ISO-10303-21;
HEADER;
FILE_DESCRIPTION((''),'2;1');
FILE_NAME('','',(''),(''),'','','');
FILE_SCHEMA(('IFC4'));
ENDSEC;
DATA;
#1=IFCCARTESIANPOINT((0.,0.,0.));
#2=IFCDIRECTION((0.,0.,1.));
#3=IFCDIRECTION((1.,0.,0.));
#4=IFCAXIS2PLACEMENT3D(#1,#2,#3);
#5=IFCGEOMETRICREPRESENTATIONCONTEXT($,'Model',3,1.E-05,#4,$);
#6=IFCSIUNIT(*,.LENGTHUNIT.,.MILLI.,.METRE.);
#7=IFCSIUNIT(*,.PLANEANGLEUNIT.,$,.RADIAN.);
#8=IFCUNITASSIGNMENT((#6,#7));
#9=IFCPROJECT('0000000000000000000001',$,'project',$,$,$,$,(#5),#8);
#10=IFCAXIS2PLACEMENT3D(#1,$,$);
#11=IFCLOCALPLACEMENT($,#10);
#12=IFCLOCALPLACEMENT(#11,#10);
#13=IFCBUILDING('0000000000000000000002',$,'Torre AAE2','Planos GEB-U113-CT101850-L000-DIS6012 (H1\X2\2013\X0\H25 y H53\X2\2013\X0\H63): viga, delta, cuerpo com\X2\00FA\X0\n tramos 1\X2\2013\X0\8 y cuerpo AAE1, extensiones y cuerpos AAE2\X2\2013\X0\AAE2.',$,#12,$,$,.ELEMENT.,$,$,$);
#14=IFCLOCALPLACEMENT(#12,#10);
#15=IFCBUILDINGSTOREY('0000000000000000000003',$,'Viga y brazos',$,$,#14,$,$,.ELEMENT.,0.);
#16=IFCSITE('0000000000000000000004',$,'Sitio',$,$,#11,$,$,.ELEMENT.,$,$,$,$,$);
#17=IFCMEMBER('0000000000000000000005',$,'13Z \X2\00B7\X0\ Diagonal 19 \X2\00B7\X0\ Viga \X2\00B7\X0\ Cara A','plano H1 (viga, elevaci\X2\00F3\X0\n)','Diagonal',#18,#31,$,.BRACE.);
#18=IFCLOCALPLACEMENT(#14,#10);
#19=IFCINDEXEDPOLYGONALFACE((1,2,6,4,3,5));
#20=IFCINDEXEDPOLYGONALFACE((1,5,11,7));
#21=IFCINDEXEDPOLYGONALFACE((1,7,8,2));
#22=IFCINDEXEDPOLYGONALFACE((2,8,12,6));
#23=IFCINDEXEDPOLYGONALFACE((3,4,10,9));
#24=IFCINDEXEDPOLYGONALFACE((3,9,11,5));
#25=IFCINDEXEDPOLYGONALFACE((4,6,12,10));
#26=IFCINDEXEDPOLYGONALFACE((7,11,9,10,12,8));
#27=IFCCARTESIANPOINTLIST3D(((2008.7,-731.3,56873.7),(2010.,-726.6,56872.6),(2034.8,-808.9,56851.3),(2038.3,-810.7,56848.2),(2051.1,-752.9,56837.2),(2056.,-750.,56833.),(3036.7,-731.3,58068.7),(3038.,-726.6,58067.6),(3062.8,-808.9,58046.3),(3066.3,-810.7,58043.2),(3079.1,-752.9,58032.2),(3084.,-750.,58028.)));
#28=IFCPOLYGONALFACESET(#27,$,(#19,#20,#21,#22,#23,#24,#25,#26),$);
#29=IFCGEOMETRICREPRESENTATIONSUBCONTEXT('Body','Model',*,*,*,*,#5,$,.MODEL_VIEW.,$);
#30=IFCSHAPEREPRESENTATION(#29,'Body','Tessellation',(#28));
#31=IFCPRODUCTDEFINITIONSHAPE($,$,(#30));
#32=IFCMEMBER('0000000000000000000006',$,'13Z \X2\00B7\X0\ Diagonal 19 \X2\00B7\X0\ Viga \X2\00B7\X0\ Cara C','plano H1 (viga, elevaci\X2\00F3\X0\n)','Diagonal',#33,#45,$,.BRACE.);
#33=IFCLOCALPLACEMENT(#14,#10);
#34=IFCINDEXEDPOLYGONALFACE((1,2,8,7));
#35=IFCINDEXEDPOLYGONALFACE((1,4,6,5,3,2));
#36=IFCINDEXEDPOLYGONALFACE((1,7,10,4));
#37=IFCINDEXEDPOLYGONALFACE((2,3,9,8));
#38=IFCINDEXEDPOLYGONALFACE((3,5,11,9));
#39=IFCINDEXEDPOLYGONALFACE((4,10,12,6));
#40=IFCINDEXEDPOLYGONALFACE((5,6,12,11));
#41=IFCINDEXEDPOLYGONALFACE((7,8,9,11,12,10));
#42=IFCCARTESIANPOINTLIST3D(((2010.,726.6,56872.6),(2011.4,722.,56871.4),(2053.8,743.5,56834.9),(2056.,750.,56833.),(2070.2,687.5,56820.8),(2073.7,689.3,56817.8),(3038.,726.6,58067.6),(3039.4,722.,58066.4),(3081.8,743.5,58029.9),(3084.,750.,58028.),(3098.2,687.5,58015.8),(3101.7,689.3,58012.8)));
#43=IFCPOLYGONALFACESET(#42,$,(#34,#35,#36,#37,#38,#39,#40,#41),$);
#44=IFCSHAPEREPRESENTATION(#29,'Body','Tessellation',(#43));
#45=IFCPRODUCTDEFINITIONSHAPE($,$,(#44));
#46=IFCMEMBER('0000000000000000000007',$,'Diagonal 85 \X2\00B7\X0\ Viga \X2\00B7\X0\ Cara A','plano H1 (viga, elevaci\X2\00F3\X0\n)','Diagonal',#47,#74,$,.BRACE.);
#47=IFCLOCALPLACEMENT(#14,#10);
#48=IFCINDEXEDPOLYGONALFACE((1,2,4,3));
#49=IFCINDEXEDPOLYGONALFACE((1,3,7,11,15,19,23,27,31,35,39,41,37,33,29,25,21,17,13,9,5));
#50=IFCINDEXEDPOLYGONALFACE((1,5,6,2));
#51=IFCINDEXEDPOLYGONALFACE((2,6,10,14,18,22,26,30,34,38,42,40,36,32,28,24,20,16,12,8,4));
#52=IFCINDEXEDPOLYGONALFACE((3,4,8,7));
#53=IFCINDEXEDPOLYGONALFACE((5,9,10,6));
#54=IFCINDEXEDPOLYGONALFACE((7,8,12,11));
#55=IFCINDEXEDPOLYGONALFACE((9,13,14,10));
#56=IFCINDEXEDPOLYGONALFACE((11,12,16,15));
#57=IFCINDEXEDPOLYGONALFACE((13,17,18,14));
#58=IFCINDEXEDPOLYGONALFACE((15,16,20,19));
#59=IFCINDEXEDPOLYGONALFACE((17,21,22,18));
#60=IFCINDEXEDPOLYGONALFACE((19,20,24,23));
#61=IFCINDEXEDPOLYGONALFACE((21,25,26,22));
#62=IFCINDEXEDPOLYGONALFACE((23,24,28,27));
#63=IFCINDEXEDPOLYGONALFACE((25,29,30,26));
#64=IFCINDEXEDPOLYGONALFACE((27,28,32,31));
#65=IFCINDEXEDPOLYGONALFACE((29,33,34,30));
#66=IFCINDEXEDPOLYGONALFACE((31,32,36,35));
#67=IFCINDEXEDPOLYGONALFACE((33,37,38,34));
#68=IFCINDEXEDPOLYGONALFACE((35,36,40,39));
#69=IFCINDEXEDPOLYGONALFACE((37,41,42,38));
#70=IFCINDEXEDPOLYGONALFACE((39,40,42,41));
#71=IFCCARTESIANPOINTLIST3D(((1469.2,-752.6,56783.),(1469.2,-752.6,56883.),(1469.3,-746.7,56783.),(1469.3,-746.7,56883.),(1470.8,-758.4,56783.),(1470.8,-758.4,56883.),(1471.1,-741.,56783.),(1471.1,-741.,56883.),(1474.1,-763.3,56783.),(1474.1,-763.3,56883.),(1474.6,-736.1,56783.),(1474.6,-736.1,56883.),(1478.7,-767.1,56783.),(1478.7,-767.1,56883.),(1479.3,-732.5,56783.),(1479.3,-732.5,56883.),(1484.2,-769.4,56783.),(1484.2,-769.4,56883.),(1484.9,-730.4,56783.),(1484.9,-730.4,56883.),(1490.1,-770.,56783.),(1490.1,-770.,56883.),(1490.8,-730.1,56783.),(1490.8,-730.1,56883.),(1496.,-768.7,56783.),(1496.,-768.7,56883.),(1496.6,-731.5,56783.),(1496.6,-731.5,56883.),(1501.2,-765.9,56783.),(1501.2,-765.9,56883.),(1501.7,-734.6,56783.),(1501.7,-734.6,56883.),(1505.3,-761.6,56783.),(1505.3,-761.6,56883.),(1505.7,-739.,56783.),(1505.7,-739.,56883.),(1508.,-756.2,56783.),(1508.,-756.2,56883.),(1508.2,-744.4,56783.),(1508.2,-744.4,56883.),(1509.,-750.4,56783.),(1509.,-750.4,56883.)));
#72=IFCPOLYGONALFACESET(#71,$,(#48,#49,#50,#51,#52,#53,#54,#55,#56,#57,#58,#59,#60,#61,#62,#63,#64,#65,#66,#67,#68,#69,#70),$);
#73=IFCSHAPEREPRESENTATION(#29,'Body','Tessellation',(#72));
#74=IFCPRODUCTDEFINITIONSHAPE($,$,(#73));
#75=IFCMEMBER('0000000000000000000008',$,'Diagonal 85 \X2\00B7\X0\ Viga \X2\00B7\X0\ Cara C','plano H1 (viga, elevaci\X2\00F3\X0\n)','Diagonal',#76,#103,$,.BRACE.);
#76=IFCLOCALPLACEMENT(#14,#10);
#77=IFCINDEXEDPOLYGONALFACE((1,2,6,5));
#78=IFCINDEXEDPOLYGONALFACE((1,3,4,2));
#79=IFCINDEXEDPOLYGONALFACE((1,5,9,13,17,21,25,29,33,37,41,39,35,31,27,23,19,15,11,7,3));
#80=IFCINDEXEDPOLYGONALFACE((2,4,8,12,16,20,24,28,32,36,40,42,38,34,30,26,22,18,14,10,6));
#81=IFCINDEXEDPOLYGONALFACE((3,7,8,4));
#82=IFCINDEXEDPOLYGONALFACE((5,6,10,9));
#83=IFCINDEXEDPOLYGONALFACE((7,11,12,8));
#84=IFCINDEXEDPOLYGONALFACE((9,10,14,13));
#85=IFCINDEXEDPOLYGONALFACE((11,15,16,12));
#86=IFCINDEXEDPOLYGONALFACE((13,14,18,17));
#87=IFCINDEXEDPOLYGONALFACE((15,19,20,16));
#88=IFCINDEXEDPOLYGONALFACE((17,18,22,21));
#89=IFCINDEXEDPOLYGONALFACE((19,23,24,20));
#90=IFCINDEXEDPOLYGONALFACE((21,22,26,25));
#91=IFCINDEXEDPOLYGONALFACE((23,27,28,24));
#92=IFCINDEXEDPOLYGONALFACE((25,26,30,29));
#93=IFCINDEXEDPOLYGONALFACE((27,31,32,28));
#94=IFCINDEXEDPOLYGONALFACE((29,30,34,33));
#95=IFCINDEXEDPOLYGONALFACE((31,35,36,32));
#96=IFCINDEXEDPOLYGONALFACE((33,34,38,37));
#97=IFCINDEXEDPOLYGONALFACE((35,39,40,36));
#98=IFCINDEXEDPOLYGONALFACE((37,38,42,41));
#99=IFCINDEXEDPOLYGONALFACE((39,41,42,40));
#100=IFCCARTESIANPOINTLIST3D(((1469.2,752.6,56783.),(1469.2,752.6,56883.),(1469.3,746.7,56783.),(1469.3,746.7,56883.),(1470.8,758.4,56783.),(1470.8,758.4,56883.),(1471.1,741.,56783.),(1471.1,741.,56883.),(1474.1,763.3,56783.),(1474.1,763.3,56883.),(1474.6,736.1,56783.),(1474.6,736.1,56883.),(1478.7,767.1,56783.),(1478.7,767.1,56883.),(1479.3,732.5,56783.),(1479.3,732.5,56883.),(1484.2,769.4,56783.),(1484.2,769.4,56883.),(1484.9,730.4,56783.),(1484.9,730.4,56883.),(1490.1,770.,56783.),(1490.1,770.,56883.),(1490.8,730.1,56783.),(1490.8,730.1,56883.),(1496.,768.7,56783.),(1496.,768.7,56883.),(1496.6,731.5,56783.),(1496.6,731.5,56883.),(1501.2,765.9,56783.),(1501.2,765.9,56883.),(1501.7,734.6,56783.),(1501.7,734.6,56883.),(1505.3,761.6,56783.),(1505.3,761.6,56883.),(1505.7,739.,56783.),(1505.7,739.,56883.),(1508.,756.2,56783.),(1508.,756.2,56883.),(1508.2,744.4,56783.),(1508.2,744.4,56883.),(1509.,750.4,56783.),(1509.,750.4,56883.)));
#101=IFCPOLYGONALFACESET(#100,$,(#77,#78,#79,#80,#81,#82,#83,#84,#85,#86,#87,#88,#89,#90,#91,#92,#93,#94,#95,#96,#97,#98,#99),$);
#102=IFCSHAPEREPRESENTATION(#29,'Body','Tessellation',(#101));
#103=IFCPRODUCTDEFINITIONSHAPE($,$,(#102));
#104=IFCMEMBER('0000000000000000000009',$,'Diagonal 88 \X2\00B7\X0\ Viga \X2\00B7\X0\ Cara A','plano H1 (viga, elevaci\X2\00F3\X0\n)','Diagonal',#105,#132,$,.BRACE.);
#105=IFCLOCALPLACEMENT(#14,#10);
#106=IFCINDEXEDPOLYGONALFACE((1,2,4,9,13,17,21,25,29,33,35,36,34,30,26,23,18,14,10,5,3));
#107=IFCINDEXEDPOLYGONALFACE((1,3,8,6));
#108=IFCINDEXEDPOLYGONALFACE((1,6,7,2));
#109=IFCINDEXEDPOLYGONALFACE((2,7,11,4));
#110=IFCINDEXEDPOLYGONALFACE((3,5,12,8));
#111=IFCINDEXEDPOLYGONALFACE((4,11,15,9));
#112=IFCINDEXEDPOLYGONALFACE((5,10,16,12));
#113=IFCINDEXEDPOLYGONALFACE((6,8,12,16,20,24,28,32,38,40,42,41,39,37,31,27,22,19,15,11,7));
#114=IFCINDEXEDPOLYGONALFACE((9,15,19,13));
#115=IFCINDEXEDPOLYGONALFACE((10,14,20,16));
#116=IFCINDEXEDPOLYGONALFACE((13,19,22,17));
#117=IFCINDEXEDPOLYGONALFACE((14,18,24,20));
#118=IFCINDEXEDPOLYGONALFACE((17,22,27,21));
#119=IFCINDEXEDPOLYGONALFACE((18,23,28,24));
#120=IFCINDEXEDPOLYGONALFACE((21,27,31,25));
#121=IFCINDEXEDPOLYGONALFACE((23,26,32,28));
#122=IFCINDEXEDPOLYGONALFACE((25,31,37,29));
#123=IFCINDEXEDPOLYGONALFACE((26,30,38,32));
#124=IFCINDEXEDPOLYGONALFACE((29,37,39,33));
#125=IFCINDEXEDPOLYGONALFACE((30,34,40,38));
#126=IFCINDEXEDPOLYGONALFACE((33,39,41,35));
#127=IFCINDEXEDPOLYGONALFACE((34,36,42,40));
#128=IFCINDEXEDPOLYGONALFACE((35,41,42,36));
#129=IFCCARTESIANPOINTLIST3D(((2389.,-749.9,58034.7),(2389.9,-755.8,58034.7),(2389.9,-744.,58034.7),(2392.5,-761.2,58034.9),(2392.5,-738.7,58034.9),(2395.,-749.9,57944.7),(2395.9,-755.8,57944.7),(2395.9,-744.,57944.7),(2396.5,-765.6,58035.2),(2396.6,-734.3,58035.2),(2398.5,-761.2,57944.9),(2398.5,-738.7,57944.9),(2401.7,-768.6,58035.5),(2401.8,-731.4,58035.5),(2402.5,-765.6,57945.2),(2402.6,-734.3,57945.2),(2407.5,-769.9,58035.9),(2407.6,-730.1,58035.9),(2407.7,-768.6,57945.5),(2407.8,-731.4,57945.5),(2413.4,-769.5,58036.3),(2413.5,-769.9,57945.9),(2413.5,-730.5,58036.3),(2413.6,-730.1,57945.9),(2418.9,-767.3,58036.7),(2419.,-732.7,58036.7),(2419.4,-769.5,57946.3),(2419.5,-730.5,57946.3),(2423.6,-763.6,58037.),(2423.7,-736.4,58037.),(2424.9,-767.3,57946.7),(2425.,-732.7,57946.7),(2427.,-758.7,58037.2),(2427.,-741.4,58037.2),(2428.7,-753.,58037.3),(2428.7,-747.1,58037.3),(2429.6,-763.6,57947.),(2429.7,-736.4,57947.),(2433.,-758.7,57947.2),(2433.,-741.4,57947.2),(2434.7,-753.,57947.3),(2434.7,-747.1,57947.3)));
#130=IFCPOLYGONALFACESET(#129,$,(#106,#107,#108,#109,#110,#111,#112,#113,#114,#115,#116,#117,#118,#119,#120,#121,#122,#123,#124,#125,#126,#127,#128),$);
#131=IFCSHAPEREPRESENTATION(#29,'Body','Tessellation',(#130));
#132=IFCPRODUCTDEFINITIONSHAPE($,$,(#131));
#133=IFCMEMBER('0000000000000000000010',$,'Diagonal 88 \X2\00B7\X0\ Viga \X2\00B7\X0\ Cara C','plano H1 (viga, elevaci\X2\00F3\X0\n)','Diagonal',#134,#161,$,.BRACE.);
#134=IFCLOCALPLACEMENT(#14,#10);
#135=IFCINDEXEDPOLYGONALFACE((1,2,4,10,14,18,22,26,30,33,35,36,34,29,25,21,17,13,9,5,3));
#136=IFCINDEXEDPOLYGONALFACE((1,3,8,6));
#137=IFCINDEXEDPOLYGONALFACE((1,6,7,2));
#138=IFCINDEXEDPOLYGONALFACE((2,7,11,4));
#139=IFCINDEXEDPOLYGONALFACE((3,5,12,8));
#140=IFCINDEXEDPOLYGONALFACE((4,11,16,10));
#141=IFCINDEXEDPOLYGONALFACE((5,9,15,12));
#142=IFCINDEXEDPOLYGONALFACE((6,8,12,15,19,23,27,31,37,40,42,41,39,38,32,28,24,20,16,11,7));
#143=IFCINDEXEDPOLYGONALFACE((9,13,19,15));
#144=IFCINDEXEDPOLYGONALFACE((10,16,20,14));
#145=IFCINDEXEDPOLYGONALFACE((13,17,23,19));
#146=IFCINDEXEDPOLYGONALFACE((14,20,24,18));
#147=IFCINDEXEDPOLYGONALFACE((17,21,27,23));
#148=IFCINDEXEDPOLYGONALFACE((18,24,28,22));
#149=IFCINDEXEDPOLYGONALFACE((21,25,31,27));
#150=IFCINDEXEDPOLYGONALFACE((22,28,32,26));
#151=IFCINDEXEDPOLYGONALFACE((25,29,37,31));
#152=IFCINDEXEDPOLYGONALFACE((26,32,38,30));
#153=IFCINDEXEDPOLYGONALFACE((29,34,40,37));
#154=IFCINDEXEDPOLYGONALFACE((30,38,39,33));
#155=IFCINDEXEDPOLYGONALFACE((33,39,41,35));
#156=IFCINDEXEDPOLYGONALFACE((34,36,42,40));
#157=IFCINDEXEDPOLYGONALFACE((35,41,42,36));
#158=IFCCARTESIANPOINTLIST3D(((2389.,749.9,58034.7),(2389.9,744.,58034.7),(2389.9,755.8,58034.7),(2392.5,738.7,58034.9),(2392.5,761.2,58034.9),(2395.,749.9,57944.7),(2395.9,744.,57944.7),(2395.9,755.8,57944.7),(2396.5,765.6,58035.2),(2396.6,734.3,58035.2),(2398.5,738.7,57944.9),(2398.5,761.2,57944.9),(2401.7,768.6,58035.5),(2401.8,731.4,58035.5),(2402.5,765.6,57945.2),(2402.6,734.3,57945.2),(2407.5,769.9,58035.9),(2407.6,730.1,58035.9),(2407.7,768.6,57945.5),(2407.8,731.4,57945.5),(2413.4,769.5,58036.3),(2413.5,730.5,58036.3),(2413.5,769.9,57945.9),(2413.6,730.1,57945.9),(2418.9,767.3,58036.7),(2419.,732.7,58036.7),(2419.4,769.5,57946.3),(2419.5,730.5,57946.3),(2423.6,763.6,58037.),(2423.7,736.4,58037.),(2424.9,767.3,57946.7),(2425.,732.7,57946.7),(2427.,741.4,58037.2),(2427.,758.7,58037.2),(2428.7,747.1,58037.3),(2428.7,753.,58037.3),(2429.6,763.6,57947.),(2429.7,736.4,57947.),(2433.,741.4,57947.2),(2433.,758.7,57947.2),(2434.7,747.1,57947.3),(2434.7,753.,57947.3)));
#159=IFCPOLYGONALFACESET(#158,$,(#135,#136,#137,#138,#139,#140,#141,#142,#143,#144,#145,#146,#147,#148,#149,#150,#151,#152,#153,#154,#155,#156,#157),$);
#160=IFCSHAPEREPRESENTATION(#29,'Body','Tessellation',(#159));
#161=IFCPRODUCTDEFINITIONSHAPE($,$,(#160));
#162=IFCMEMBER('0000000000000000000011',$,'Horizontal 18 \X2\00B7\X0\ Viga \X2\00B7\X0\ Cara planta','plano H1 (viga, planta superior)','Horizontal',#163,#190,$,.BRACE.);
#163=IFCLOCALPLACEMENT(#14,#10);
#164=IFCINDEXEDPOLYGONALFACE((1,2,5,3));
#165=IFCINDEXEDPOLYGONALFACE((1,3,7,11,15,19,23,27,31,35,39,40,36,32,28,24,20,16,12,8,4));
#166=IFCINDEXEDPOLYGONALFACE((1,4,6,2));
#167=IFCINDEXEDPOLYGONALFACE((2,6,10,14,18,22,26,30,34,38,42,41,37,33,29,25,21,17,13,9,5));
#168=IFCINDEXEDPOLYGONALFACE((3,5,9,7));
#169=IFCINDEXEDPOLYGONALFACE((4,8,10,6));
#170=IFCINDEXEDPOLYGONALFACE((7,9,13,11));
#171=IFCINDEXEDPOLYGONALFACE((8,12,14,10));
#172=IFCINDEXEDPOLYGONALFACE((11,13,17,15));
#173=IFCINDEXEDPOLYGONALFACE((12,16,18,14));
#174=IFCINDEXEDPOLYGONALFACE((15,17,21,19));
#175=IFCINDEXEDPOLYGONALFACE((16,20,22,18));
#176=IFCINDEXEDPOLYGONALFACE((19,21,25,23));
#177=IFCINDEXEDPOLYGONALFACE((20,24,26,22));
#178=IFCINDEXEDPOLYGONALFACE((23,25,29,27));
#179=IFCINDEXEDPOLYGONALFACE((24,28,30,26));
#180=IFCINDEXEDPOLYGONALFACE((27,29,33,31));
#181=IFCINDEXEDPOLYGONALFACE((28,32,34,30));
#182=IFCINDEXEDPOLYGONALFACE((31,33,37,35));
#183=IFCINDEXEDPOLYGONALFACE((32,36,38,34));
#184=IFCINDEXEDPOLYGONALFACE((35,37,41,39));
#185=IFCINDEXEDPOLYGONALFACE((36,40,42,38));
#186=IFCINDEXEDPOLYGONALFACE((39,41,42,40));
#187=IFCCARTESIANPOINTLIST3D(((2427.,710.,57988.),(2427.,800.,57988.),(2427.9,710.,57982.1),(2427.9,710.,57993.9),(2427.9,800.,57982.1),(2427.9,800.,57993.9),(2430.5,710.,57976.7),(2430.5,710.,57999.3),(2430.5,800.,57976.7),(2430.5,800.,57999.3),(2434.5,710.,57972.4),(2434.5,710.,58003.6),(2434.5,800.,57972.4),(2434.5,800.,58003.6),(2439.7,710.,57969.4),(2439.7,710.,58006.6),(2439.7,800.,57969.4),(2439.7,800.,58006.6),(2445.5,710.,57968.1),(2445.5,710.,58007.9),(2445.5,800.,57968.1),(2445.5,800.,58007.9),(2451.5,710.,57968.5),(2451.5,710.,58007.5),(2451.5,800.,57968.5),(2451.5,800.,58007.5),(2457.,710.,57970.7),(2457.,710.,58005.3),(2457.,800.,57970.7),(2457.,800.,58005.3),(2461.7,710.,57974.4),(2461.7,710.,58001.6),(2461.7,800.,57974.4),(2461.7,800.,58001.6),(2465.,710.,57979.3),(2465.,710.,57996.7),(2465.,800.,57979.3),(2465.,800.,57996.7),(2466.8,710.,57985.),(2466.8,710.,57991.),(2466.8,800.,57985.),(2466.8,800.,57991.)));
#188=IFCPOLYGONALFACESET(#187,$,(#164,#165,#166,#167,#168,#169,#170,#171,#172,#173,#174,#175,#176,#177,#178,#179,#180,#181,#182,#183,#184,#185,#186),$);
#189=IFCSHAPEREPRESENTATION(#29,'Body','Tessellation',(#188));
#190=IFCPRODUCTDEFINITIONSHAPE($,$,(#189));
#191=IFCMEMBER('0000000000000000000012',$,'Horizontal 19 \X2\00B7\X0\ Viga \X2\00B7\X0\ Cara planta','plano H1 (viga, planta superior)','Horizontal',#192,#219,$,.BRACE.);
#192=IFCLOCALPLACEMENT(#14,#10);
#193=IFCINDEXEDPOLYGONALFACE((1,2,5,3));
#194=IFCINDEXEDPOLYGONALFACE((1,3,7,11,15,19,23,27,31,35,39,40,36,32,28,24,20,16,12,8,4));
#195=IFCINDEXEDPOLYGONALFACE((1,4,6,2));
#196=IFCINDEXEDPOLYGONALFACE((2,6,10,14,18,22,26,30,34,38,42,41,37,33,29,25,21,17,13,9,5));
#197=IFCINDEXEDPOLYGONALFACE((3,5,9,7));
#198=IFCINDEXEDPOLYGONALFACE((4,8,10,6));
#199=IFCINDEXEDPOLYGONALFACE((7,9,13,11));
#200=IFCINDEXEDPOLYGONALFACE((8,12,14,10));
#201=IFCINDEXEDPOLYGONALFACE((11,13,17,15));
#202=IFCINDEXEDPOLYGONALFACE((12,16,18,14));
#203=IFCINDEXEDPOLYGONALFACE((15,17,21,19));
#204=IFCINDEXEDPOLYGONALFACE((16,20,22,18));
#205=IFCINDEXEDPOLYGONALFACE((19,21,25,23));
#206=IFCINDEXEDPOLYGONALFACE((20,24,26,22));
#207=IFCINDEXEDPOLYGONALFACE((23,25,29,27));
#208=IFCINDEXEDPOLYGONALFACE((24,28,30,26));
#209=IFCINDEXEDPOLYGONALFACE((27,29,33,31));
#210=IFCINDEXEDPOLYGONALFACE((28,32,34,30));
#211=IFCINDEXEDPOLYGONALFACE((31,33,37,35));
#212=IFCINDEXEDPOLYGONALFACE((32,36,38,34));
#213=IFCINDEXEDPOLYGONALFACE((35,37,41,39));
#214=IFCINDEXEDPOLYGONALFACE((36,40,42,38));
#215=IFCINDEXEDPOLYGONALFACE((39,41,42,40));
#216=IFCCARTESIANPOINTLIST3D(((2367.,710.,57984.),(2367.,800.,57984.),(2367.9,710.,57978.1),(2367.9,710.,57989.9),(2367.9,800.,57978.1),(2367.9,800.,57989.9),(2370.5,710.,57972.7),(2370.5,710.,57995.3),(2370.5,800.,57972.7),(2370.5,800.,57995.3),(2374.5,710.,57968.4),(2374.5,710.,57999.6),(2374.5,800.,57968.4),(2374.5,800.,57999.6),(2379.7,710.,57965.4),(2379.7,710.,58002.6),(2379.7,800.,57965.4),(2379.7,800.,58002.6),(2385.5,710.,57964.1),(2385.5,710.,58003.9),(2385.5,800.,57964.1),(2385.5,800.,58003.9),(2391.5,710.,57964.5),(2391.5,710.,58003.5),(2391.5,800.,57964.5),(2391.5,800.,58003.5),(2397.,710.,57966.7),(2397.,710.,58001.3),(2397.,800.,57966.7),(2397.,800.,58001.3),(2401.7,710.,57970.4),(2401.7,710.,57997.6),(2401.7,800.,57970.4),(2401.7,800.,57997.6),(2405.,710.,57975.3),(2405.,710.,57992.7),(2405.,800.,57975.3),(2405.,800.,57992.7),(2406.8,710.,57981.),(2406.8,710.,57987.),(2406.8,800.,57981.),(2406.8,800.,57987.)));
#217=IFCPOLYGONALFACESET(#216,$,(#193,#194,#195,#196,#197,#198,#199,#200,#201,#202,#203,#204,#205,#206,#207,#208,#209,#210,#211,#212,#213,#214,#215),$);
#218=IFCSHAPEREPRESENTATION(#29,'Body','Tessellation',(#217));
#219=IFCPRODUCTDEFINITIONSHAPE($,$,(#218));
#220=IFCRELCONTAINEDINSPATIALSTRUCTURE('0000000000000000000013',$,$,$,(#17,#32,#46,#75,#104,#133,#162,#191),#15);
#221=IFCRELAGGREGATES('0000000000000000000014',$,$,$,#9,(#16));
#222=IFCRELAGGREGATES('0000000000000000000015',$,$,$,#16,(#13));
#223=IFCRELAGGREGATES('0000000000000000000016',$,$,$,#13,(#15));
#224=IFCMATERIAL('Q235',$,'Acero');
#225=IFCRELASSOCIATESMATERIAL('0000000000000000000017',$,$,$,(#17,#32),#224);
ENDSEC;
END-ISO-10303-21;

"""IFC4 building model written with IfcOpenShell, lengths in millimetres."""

from ifc_helpers import new_model, si_unit, frame, frame_2d, origin, origin_with_axes, place, context, subcontext, project, spatial, circle, l_section, extrude, material, element, save


model = new_model("IFC4")

# Units and contexts
model_context = context("Model", 3, precision=1e-05, world=origin_with_axes())
body_context = subcontext(model_context, "Body", "Model", "MODEL_VIEW")
ifc_project = project(units=[si_unit("LENGTHUNIT", "METRE", prefix="MILLI"), si_unit("PLANEANGLEUNIT", "RADIAN")], contexts=[model_context])

# Site, building, storey
site_placement = place(None, origin())
site = spatial("IfcSite", under=ifc_project, at=site_placement, Name="Sitio", CompositionType="ELEMENT")
building_placement = place(site_placement, origin())
building = spatial("IfcBuilding", under=site, at=building_placement, Name="Torre AAE2", Description="Planos GEB-U113-CT101850-L000-DIS6012 (H1–H25 y H53–H63): viga, delta, cuerpo común tramos 1–8 y cuerpo AAE1, extensiones y cuerpos AAE2–AAE2.", CompositionType="ELEMENT")
storey_placement = place(building_placement, origin())
storey = spatial("IfcBuildingStorey", under=building, at=storey_placement, Name="Viga y brazos", CompositionType="ELEMENT", Elevation=0.0)

# Members
ifc_material = material(Name="Q235", Category="Acero")
for number, where, z_axis, x_axis, name in (
    (1, (2056.0, -750.0, 56833.0), (0.652149, 0.0, 0.758091), (-0.707481, 0.359253, 0.608611), "13Z · Diagonal 19 · Viga · Cara A"),
    (2, (2056.0, 750.0, 56833.0), (0.652149, 0.0, 0.758091), (-0.707481, -0.359253, 0.608611), "13Z · Diagonal 19 · Viga · Cara C"),
):
    element("IfcMember", number, at=place(storey_placement, frame(where, z_axis=z_axis, x_axis=x_axis)), inside=storey, material=ifc_material, Name=name, Description="plano H1 (viga, elevación)", ObjectType="Diagonal", PredefinedType="BRACE", context=body_context, shape_type="SweptSolid", body=[
        extrude(l_section(Depth=65.0, Width=65.0, Thickness=5.0, at=frame_2d((32.5, 32.5))), None, (0.0, 0.0, 1.0), 1576.3),
    ])
for number, where, z_axis, x_axis, name in (
    (3, (1489.0, -750.0, 56883.0), (0.0, 0.0, -1.0), (-0.893104, 0.449851, 0.0), "Diagonal 85 · Viga · Cara A"),
    (4, (1489.0, 750.0, 56883.0), (0.0, 0.0, -1.0), (-0.893104, -0.449851, 0.0), "Diagonal 85 · Viga · Cara C"),
):
    element("IfcMember", number, at=place(storey_placement, frame(where, z_axis=z_axis, x_axis=x_axis)), inside=storey, Name=name, Description="plano H1 (viga, elevación)", ObjectType="Diagonal", PredefinedType="BRACE", context=body_context, shape_type="SweptSolid", body=[
        extrude(circle(Radius=20.0), None, (0.0, 0.0, 1.0), 100.0),
    ])
for number, where, z_axis, x_axis, name in (
    (5, (2415.0, -750.0, 57946.0), (-0.066519, 0.0, 0.997785), (-0.9526, 0.297523, -0.063507), "Diagonal 88 · Viga · Cara A"),
    (6, (2415.0, 750.0, 57946.0), (-0.066519, 0.0, 0.997785), (-0.9526, -0.297523, -0.063507), "Diagonal 88 · Viga · Cara C"),
):
    element("IfcMember", number, at=place(storey_placement, frame(where, z_axis=z_axis, x_axis=x_axis)), inside=storey, Name=name, Description="plano H1 (viga, elevación)", ObjectType="Diagonal", PredefinedType="BRACE", context=body_context, shape_type="SweptSolid", body=[
        extrude(circle(Radius=20.0), None, (0.0, 0.0, 1.0), 90.2),
    ])
for number, where, z_axis, x_axis, name in (
    (7, (2447.0, 710.0, 57988.0), (0.0, 1.0, 0.0), (-1.0, 0.0, 0.0), "Horizontal 18 · Viga · Cara planta"),
    (8, (2387.0, 710.0, 57984.0), (0.0, 1.0, 0.0), (-1.0, 0.0, 0.0), "Horizontal 19 · Viga · Cara planta"),
):
    element("IfcMember", number, at=place(storey_placement, frame(where, z_axis=z_axis, x_axis=x_axis)), inside=storey, Name=name, Description="plano H1 (viga, planta superior)", ObjectType="Horizontal", PredefinedType="BRACE", context=body_context, shape_type="SweptSolid", body=[
        extrude(circle(Radius=20.0), None, (0.0, 0.0, 1.0), 90.0),
    ])

save(model, "model.ifc")
